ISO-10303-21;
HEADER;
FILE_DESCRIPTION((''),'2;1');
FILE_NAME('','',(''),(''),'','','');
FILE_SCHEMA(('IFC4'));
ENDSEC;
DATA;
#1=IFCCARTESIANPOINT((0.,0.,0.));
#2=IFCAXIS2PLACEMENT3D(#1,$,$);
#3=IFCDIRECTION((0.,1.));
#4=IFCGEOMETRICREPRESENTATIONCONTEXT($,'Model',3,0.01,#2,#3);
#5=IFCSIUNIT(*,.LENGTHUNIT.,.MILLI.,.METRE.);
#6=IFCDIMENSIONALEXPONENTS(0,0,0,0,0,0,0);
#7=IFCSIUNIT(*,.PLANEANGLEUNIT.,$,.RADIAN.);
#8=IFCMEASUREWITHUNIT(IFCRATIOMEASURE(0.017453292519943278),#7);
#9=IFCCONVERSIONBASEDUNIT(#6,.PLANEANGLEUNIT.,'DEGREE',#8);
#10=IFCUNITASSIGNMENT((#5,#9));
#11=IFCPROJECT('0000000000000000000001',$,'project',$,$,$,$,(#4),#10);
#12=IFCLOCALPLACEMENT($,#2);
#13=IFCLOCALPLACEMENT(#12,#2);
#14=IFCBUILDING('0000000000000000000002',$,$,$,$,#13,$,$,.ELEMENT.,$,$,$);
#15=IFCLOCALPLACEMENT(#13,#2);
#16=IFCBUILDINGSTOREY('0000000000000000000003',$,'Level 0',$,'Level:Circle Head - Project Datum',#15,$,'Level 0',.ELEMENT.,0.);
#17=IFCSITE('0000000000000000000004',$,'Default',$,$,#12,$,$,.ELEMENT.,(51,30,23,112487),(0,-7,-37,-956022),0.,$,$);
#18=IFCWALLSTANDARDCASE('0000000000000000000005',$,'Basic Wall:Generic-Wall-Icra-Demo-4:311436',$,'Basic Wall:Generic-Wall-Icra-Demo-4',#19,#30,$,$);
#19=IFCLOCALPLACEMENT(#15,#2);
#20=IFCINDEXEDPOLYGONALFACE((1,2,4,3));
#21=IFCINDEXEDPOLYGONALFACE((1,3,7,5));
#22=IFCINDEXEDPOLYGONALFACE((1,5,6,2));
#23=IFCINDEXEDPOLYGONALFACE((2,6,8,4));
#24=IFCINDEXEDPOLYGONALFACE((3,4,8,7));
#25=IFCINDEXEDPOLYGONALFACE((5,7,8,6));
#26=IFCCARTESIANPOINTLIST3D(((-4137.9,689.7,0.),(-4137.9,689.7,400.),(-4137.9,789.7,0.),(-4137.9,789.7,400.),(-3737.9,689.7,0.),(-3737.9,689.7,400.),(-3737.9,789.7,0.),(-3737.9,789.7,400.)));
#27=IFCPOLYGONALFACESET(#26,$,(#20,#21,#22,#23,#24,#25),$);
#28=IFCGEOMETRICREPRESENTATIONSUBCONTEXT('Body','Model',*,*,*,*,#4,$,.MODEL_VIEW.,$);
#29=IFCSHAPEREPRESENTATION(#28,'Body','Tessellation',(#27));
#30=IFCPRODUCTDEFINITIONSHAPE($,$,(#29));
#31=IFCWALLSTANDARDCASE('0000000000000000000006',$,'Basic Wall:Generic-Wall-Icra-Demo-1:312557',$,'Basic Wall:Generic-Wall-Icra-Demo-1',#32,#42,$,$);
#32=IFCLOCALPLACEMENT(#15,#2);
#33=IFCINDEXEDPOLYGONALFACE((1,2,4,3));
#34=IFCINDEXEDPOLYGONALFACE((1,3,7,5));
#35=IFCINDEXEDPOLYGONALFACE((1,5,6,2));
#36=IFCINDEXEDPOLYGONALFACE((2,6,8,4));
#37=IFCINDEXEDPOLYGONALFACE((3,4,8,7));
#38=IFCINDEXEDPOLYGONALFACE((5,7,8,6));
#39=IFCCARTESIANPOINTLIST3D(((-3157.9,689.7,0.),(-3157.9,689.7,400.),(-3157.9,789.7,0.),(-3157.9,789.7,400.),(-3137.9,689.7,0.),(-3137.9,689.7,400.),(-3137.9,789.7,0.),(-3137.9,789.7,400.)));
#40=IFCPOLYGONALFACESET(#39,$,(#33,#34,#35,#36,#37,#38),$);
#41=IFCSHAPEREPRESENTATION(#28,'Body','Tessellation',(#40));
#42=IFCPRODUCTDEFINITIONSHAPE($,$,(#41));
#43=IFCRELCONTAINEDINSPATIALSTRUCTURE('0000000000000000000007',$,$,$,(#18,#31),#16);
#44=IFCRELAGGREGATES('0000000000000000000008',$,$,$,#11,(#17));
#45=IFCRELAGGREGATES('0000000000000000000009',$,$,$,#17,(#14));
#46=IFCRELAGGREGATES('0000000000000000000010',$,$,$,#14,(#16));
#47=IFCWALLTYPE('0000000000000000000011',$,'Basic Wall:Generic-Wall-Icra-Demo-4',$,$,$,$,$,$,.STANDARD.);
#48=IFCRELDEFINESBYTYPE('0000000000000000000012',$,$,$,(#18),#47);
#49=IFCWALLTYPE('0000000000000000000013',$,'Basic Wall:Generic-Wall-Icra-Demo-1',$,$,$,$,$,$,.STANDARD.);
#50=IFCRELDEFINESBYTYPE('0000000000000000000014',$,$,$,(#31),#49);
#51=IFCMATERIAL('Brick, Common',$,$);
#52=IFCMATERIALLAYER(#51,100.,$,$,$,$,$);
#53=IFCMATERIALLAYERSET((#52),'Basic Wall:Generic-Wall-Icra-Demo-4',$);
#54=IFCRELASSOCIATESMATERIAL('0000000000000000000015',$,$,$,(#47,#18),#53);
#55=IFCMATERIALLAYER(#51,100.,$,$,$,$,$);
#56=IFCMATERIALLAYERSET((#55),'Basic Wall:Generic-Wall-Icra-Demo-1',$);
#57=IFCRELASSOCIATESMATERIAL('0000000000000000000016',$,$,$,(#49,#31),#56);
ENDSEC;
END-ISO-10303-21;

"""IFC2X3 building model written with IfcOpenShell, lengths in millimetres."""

from ifc_helpers import new_model, entity, si_unit, converted_unit, direction, frame, frame_2d, origin, place, context, subcontext, project, spatial, rectangle, extrude, material, layer, layer_set, layer_usage, type_object, element, save


model = new_model("IFC2X3")

# Units and contexts
model_context = context("Model", 3, precision=0.01, world=origin(), true_north=direction((0.0, 1.0)))
body_context = subcontext(model_context, "Body", "Model", "MODEL_VIEW")
ifc_project = project(units=[si_unit("LENGTHUNIT", "METRE", prefix="MILLI"), converted_unit("PLANEANGLEUNIT", "DEGREE", entity("IfcRatioMeasure", 0.017453292519943278), si_unit("PLANEANGLEUNIT", "RADIAN"), dimensions=[0, 0, 0, 0, 0, 0, 0])], contexts=[model_context])

# Site, building, storey
site_placement = place(None, origin())
site = spatial("IfcSite", under=ifc_project, at=site_placement, Name="Default", CompositionType="ELEMENT", RefLatitude=(51, 30, 23, 112487), RefLongitude=(0, -7, -37, -956022), RefElevation=0.0)
building_placement = place(site_placement, origin())
building = spatial("IfcBuilding", under=site, at=building_placement, CompositionType="ELEMENT")
storey_placement = place(building_placement, origin())
storey = spatial("IfcBuildingStorey", under=building, at=storey_placement, Name="Level 0", ObjectType="Level:Circle Head - Project Datum", LongName="Level 0", CompositionType="ELEMENT", Elevation=0.0)

# Wall
ifc_material = material(Name="Brick, Common")
ifc_layer_1 = layer(ifc_material, 100.0)
ifc_layer_set_1 = layer_set([ifc_layer_1], Name="Basic Wall:Generic-Wall-Icra-Demo-4")
ifc_layer_usage_1 = layer_usage(ifc_layer_set_1, "AXIS2", "NEGATIVE", 50.0)
wall_type_1 = type_object("IfcWallType", Name="Basic Wall:Generic-Wall-Icra-Demo-4", PredefinedType="STANDARD", material=ifc_layer_set_1)
wall_1_placement = place(storey_placement, frame((-4137.9, 739.7, 0.0)))
element("IfcWallStandardCase", 1, at=wall_1_placement, inside=storey, type_object=wall_type_1, material=ifc_layer_usage_1, Name="Basic Wall:Generic-Wall-Icra-Demo-4:311436", ObjectType="Basic Wall:Generic-Wall-Icra-Demo-4", context=body_context, shape_type="SweptSolid", body=[
    extrude(rectangle(XDim=400.0, YDim=100.0, at=frame_2d((200.0, 0.0), x_axis=(-1.0, 0.0))), origin(), (0.0, 0.0, 1.0), 400.0),
])

# Wall, opening
ifc_layer_2 = layer(ifc_material, 100.0)
ifc_layer_set_2 = layer_set([ifc_layer_2], Name="Basic Wall:Generic-Wall-Icra-Demo-1")
ifc_layer_usage_2 = layer_usage(ifc_layer_set_2, "AXIS2", "NEGATIVE", 50.0)
wall_type_2 = type_object("IfcWallType", Name="Basic Wall:Generic-Wall-Icra-Demo-1", PredefinedType="STANDARD", material=ifc_layer_set_2)
wall_2_placement = place(storey_placement, frame((-3157.9, 739.7, 0.0)))
wall_2 = element("IfcWallStandardCase", 2, at=wall_2_placement, inside=storey, type_object=wall_type_2, material=ifc_layer_usage_2, Name="Basic Wall:Generic-Wall-Icra-Demo-1:312557", ObjectType="Basic Wall:Generic-Wall-Icra-Demo-1", context=body_context, shape_type="SweptSolid", body=[
    extrude(rectangle(XDim=100.0, YDim=20.0, at=frame_2d((10.0, 0.0), x_axis=(0.0, -1.0))), origin(), (0.0, 0.0, 1.0), 400.0),
])
opening_placement = place(wall_2_placement, frame((-400.0, -50.0, 0.0)))
element("IfcOpeningElement", 3, at=opening_placement, cuts=wall_2, ObjectType="Opening", context=body_context, shape_type="SweptSolid", body=[
    extrude(rectangle(XDim=400.0, YDim=400.0, at=frame_2d((200.0, 200.0), x_axis=(1.0, 0.0))), frame((0.0, 0.0, 0.0), z_axis=(0.0, 1.0, 0.0), x_axis=(0.0, 0.0, 1.0)), (0.0, 0.0, 1.0), 100.0),
])

save(model, "model.ifc")
